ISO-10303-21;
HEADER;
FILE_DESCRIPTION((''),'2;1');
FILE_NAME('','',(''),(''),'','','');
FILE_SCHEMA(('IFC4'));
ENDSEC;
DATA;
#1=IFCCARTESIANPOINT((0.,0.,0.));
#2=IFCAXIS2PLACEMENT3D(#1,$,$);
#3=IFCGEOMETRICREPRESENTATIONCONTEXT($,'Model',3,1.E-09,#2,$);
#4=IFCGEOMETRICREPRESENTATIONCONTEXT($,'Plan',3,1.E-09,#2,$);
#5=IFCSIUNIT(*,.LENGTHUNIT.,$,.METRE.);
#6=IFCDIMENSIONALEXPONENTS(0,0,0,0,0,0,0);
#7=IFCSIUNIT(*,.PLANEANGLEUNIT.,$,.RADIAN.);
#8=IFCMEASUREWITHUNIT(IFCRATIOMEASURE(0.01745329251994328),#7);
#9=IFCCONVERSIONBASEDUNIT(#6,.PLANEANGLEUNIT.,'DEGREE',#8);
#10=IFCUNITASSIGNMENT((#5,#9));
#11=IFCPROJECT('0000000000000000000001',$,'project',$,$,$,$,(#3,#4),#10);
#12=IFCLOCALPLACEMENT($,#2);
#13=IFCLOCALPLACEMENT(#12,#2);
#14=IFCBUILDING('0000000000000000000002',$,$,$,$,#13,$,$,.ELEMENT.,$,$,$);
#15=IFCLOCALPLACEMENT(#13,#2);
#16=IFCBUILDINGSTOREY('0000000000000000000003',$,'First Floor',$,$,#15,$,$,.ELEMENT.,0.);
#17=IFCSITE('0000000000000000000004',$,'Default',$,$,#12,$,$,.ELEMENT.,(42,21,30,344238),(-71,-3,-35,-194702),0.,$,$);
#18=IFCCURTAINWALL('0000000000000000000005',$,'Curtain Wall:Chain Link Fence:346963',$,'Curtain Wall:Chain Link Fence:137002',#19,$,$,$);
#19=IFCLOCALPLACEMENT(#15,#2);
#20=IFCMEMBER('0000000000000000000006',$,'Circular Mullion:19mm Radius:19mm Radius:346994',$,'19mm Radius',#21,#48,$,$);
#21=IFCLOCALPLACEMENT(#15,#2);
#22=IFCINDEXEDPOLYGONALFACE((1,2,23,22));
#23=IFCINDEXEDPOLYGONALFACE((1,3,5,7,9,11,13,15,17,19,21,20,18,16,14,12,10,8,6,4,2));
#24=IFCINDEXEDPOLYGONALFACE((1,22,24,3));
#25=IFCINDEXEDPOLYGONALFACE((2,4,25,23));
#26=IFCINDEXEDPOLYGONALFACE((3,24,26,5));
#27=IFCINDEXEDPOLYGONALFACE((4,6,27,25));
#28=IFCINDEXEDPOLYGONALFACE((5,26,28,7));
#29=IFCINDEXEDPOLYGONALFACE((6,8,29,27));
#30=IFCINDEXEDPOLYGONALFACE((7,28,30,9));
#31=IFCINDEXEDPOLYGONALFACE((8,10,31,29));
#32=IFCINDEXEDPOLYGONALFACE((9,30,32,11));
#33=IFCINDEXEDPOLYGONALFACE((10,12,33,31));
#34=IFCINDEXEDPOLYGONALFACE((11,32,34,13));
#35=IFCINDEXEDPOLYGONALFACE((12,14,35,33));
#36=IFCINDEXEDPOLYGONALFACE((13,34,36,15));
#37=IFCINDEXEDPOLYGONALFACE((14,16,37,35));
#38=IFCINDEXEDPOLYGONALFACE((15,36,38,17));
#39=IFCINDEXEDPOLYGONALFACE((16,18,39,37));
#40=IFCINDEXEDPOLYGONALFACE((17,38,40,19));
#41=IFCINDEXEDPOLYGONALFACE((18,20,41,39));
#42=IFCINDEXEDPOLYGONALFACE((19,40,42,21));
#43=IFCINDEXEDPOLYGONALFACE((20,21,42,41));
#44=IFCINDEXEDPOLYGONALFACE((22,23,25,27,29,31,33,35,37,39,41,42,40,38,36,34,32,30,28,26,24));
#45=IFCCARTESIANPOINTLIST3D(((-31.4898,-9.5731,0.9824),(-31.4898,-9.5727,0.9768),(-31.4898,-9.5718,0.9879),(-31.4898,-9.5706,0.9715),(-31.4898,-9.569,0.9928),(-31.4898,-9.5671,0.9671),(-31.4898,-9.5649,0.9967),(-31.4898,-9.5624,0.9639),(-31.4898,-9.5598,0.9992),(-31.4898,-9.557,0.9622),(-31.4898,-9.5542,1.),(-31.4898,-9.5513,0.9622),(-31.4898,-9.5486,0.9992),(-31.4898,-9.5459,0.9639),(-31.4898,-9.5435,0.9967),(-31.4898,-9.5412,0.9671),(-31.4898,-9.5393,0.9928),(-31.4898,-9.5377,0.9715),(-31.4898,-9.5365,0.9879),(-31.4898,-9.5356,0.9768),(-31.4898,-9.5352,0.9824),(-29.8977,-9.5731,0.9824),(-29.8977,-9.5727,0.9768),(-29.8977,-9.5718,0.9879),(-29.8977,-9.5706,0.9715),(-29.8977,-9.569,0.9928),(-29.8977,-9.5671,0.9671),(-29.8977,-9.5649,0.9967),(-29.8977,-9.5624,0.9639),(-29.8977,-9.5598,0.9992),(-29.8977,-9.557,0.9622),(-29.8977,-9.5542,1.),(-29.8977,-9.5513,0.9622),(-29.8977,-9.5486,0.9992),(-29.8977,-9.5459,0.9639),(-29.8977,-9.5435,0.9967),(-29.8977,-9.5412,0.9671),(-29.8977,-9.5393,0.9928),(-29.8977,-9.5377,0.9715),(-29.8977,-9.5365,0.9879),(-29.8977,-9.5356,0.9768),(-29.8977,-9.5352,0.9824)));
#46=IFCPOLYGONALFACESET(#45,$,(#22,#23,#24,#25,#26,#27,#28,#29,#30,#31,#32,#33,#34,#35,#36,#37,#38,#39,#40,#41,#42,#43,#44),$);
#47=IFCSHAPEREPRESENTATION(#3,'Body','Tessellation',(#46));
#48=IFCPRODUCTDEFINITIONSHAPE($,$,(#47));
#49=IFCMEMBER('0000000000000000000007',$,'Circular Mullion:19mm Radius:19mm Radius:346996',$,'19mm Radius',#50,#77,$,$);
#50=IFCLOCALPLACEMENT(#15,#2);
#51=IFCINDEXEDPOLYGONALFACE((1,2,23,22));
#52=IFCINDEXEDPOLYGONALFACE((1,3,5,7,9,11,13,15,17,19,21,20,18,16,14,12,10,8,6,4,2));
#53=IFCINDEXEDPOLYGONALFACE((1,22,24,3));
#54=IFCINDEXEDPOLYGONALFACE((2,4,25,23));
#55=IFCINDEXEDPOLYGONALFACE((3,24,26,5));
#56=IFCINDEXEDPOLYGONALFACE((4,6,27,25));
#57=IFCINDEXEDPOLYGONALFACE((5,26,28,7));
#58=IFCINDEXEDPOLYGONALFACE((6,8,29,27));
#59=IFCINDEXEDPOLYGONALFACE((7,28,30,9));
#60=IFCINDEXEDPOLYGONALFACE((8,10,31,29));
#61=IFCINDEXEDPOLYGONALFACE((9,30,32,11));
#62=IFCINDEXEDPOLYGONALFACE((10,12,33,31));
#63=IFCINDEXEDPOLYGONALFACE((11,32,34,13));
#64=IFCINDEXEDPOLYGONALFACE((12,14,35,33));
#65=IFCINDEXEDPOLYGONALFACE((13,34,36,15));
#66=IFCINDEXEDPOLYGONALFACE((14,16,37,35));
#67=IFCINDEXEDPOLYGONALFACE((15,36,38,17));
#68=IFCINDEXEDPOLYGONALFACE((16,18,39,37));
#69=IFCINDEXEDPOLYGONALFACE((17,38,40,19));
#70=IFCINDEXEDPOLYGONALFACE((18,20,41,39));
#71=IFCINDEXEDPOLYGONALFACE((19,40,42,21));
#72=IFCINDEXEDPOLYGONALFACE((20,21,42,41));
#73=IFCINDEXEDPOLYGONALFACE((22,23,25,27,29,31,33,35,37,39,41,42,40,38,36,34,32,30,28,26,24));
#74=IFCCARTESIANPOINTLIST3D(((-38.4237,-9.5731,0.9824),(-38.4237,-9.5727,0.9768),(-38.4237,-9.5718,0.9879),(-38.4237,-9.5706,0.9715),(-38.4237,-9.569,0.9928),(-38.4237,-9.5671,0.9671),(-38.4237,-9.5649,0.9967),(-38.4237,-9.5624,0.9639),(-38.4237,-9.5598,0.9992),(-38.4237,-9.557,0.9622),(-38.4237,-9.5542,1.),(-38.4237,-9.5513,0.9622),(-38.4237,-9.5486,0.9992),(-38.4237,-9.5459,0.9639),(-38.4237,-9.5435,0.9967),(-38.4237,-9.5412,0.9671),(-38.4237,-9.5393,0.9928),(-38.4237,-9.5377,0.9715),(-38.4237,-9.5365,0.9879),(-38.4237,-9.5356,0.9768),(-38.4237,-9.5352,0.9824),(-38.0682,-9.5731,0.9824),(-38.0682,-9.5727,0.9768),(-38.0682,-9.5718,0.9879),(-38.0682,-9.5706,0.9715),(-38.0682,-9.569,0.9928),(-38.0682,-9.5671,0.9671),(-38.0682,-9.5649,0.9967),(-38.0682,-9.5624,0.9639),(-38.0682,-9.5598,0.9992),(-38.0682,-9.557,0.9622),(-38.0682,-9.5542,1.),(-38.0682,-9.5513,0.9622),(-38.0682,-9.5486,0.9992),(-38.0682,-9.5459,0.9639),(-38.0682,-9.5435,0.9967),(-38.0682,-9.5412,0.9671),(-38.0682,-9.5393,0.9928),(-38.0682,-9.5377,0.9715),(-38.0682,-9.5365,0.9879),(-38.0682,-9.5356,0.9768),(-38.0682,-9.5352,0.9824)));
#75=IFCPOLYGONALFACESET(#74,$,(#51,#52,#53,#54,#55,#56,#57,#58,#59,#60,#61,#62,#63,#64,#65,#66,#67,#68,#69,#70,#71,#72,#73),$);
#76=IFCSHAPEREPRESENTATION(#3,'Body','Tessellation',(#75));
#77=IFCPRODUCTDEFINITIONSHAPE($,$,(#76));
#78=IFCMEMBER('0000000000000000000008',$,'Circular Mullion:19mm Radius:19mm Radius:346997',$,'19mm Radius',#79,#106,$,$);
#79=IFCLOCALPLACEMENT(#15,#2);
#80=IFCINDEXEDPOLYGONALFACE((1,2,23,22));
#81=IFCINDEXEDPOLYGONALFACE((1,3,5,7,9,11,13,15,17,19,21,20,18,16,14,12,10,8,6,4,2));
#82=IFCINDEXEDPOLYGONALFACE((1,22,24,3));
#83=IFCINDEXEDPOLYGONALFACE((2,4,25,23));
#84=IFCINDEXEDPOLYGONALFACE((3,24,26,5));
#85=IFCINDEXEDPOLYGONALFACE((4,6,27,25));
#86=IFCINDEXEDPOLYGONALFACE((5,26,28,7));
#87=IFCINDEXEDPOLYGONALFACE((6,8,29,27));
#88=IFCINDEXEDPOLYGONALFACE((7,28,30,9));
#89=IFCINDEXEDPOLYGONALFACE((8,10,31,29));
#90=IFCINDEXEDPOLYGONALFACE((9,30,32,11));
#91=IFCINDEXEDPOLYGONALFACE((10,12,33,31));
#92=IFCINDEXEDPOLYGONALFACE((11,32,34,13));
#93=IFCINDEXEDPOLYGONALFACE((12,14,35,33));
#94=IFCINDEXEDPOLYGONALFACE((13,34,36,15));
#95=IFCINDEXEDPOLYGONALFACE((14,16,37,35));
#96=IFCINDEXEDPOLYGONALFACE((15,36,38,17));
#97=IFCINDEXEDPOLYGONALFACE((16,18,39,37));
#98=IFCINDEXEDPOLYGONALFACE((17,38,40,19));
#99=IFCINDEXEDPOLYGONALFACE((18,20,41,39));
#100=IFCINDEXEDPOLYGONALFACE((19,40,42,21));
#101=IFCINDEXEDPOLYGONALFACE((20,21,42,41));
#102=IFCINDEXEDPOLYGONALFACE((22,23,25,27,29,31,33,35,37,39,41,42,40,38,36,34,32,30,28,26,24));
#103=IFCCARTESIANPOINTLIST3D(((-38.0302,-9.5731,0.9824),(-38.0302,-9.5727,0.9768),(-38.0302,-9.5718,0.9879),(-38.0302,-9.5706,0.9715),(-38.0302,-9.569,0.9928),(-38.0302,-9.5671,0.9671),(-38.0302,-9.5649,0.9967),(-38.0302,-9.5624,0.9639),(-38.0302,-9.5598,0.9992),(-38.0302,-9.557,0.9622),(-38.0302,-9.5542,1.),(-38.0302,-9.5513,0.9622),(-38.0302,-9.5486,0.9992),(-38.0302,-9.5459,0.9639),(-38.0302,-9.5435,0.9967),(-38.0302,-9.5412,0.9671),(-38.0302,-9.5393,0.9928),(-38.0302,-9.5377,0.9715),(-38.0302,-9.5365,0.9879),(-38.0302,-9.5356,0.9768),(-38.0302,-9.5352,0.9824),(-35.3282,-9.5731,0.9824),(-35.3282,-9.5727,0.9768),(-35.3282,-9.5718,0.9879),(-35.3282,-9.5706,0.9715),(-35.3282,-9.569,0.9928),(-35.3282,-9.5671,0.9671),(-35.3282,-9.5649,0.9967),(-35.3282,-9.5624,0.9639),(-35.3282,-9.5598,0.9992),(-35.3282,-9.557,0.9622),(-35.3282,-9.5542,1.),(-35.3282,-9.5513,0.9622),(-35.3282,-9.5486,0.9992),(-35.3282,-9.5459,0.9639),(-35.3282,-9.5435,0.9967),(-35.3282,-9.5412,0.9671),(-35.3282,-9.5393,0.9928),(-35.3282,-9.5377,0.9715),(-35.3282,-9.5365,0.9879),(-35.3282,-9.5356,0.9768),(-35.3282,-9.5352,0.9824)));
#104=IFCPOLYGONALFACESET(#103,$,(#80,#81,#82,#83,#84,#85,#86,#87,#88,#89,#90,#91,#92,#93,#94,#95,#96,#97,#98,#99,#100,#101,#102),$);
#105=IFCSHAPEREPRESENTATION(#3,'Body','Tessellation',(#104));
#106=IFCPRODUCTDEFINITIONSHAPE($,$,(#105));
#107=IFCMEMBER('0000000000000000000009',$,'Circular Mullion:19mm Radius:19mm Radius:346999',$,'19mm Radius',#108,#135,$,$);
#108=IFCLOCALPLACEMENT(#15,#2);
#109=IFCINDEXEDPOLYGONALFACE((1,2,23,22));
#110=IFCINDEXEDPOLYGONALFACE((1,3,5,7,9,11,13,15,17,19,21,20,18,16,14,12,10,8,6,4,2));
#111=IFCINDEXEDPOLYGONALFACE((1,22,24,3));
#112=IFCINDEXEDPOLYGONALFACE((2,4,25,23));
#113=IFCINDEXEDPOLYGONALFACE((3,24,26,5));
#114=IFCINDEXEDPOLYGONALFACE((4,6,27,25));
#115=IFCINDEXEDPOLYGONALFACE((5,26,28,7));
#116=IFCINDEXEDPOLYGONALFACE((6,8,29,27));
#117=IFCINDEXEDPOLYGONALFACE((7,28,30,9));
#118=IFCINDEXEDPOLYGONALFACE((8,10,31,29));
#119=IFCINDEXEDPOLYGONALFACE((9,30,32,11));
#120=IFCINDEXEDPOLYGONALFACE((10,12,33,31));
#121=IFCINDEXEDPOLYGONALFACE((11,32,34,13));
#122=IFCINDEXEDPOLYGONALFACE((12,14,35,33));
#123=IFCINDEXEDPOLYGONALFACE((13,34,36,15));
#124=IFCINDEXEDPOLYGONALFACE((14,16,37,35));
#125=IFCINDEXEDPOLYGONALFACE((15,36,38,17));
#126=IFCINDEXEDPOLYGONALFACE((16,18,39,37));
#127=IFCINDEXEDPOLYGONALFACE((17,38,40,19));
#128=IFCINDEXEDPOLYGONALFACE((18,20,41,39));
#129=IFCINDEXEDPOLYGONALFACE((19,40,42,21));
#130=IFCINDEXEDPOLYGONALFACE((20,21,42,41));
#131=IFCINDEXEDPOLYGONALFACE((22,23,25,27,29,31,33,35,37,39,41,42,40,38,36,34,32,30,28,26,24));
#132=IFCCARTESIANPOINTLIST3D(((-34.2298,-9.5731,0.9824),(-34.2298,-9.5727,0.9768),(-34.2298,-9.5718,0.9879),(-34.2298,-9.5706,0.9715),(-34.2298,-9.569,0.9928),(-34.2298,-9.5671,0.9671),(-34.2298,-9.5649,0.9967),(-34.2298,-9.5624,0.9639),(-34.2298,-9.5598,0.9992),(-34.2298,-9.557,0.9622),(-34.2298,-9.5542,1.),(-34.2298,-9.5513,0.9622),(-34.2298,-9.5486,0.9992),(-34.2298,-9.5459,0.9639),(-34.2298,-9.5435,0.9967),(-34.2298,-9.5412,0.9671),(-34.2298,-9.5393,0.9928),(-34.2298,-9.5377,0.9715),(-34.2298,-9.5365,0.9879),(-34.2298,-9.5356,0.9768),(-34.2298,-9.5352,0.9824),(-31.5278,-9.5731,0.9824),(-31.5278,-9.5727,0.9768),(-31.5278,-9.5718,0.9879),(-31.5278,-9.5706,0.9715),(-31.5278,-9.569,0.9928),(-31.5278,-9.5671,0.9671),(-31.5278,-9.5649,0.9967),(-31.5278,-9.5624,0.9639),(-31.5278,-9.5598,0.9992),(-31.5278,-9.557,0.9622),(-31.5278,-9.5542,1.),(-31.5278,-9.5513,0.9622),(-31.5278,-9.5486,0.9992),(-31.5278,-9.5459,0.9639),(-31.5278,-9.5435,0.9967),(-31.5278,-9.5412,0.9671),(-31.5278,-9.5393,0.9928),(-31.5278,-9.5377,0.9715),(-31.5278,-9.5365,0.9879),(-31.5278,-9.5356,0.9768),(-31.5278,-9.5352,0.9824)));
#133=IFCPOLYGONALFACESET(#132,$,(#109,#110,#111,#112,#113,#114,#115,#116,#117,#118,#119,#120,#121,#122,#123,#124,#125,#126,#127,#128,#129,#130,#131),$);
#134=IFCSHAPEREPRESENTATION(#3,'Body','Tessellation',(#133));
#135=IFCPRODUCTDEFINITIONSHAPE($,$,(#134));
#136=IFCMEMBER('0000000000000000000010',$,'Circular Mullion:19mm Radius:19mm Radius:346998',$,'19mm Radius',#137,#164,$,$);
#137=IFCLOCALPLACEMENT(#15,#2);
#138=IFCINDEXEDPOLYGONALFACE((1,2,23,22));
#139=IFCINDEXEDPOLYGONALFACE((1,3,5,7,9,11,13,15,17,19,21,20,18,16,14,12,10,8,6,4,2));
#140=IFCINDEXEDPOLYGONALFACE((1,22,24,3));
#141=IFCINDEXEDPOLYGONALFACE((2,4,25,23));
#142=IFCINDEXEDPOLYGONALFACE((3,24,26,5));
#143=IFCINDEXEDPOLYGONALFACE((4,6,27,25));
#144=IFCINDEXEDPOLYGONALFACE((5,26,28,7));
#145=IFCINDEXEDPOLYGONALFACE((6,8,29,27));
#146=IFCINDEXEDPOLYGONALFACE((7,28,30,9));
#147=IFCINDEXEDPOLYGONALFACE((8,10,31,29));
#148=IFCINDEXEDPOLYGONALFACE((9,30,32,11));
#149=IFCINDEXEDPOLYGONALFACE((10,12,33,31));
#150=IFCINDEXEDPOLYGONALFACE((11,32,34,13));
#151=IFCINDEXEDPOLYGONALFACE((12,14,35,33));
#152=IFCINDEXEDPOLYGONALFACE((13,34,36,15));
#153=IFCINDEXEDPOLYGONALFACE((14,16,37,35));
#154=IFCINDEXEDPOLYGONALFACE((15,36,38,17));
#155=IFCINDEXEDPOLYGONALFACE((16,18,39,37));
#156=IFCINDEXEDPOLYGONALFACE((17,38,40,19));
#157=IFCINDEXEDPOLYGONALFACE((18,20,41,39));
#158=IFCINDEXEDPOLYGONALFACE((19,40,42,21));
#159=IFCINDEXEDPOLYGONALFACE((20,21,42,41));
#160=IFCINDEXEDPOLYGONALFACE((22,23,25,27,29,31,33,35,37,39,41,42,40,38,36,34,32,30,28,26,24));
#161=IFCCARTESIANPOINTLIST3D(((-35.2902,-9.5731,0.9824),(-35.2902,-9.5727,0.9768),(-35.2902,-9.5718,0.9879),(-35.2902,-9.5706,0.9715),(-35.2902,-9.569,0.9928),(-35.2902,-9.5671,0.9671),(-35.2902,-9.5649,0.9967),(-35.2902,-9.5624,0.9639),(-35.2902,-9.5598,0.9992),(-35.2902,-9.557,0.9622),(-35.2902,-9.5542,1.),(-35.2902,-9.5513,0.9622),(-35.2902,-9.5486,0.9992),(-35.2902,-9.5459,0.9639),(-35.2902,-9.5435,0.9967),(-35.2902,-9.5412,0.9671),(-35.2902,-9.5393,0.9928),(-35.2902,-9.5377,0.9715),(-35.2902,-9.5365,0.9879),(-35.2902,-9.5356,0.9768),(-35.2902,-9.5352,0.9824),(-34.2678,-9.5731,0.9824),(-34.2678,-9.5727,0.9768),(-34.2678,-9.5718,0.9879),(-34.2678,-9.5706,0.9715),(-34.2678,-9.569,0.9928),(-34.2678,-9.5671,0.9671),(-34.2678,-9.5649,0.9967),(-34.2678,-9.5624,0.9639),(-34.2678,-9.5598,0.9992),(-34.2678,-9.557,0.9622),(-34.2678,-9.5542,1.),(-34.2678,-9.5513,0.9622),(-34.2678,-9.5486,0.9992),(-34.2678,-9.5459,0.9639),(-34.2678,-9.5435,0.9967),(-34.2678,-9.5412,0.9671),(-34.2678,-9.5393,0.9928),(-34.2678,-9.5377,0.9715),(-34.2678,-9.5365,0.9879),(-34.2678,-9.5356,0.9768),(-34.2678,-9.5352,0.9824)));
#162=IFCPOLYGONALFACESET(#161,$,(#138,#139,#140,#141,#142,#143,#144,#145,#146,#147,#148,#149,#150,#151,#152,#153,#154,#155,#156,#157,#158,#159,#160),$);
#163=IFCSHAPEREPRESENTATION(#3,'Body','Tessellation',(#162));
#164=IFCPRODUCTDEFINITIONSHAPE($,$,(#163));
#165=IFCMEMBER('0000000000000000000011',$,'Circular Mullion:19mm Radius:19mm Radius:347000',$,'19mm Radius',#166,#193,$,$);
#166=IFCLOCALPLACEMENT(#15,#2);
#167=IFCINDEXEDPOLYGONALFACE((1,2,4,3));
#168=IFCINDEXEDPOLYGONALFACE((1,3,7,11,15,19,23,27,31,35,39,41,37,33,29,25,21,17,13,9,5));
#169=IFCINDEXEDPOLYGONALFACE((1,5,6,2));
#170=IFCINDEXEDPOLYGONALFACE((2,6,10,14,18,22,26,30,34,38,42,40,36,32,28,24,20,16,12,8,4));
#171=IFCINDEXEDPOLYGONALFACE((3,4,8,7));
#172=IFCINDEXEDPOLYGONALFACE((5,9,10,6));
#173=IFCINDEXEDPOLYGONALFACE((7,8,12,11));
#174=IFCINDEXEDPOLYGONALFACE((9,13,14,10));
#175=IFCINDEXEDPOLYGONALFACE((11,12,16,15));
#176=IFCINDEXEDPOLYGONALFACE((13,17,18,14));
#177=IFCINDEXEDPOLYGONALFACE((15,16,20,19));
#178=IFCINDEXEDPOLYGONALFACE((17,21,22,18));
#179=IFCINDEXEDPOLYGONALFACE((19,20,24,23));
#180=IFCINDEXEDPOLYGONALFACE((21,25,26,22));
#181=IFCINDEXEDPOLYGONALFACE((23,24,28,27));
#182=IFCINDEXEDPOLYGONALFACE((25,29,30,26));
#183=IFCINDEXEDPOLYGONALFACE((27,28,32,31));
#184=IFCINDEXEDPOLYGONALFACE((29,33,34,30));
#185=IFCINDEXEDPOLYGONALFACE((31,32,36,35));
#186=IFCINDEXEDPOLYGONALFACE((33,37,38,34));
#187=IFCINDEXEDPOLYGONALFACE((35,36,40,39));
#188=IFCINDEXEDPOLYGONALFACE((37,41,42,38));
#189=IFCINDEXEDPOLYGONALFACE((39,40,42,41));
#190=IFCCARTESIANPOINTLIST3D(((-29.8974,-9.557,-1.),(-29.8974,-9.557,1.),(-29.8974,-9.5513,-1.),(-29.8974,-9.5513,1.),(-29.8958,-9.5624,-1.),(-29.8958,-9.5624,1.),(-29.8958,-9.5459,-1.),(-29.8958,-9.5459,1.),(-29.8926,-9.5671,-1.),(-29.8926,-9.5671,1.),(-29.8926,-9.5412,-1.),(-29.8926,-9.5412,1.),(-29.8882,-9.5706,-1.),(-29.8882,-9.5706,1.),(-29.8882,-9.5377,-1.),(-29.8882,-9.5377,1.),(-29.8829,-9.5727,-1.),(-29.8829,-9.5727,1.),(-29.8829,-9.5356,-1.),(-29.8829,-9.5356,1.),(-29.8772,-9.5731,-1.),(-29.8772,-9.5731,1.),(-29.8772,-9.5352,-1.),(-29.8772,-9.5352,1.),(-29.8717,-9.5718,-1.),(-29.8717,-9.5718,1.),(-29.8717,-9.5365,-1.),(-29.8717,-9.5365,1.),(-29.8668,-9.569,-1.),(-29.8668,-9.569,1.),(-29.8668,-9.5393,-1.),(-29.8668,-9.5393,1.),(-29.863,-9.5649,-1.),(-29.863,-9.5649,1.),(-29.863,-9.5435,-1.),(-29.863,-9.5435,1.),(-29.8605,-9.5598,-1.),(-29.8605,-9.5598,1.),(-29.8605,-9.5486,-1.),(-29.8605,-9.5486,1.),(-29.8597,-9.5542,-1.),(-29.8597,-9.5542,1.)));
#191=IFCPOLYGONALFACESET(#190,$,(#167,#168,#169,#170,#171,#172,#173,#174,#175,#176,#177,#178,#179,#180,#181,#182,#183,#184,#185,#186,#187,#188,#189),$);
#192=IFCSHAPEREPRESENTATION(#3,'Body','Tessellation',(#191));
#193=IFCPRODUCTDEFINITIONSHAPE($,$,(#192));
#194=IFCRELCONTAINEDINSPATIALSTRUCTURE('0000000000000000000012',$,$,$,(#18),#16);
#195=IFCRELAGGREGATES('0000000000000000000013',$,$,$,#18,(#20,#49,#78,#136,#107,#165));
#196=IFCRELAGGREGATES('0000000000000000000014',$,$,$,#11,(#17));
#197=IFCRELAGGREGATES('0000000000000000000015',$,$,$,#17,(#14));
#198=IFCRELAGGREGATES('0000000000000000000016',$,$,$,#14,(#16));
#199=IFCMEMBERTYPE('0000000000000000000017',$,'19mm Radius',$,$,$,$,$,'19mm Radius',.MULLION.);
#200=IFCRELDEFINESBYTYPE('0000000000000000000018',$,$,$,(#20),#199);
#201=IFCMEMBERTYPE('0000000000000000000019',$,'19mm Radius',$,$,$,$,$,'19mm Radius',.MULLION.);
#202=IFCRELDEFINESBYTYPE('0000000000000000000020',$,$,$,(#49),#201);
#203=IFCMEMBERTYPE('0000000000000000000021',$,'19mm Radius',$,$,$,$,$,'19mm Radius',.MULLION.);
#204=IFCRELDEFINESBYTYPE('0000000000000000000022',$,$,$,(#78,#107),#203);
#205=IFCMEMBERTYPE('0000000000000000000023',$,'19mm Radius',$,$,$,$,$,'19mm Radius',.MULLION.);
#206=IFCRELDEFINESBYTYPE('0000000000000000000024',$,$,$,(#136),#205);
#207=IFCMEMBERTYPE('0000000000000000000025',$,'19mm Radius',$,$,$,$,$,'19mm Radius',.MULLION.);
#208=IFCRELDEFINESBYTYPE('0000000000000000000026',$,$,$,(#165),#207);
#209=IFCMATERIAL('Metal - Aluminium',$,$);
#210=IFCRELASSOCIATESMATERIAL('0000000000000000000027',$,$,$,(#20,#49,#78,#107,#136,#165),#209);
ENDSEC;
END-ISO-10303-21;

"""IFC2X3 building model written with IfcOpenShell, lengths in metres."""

from ifc_helpers import new_model, entity, si_unit, converted_unit, frame, origin, origin_2d_with_axis, place, context, project, spatial, circle, extrude, source, transform, mapped, material, type_object, type_shapes, element, aggregate, save


model = new_model("IFC2X3")

# Units and contexts
model_context = context("Model", 3, precision=1e-09, world=origin())
plan_context = context("Plan", 3, precision=1e-09, world=origin())
ifc_project = project(units=[si_unit("LENGTHUNIT", "METRE"), converted_unit("PLANEANGLEUNIT", "DEGREE", entity("IfcRatioMeasure", 0.01745329251994328), si_unit("PLANEANGLEUNIT", "RADIAN"), dimensions=[0, 0, 0, 0, 0, 0, 0])], contexts=[model_context, plan_context])

# Site, building, storey
site_placement = place(None, origin())
site = spatial("IfcSite", under=ifc_project, at=site_placement, Name="Default", CompositionType="ELEMENT", RefLatitude=(42, 21, 30, 344238), RefLongitude=(-71, -3, -35, -194702), RefElevation=0.0)
building_placement = place(site_placement, origin())
building = spatial("IfcBuilding", under=site, at=building_placement, CompositionType="ELEMENT")
storey_placement = place(building_placement, origin())
storey = spatial("IfcBuildingStorey", under=building, at=storey_placement, Name="First Floor", CompositionType="ELEMENT", Elevation=0.0)

# Curtain wall, members
curtain_wall_1_placement = place(storey_placement, origin())
curtain_wall_1 = element("IfcCurtainWall", 1, at=curtain_wall_1_placement, inside=storey, Name="Curtain Wall:Chain Link Fence:346963", ObjectType="Curtain Wall:Chain Link Fence:137002")
ifc_material_1 = material(Name="Metal - Aluminium")
member_type_1 = type_object("IfcMemberType", Name="19mm Radius", ElementType="19mm Radius", PredefinedType="MULLION")
shared_shape_1 = source(origin(), model_context, "Body", "SweptSolid", [
    extrude(circle(Radius=0.019, at=origin_2d_with_axis()), frame((-0.019, 0.0, -1.5921)), (0.0, 0.0, 1.0), 1.5921),
])
type_shapes(member_type_1, [shared_shape_1])
member_1_placement = place(storey_placement, frame((-29.8977, -9.5542, 1.0), z_axis=(1.0, 0.0, 0.0), x_axis=(0.0, 0.0, 1.0)))
member_1 = element("IfcMember", 2, at=member_1_placement, type_object=member_type_1, material=ifc_material_1, Name="Circular Mullion:19mm Radius:19mm Radius:346994", ObjectType="19mm Radius", context=model_context, shape_type="MappedRepresentation", body=[
    mapped(shared_shape_1, transform((0.0, 0.0, 0.0), scale=1.0)),
])
member_type_2 = type_object("IfcMemberType", Name="19mm Radius", ElementType="19mm Radius", PredefinedType="MULLION")
shared_shape_2 = source(origin(), model_context, "Body", "SweptSolid", [
    extrude(circle(Radius=0.019, at=origin_2d_with_axis()), frame((-0.019, 0.0, -0.3556)), (0.0, 0.0, 1.0), 0.3556),
])
type_shapes(member_type_2, [shared_shape_2])
member_2_placement = place(storey_placement, frame((-38.0682, -9.5542, 1.0), z_axis=(1.0, 0.0, 0.0), x_axis=(0.0, 0.0, 1.0)))
member_2 = element("IfcMember", 3, at=member_2_placement, type_object=member_type_2, material=ifc_material_1, Name="Circular Mullion:19mm Radius:19mm Radius:346996", ObjectType="19mm Radius", context=model_context, shape_type="MappedRepresentation", body=[
    mapped(shared_shape_2, transform((0.0, 0.0, 0.0), scale=1.0)),
])
member_type_3 = type_object("IfcMemberType", Name="19mm Radius", ElementType="19mm Radius", PredefinedType="MULLION")
shared_shape_3 = source(origin(), model_context, "Body", "SweptSolid", [
    extrude(circle(Radius=0.019, at=origin_2d_with_axis()), frame((-0.019, 0.0, -2.702)), (0.0, 0.0, 1.0), 2.702),
])
type_shapes(member_type_3, [shared_shape_3])
member_3_placement = place(storey_placement, frame((-35.3282, -9.5542, 1.0), z_axis=(1.0, 0.0, 0.0), x_axis=(0.0, 0.0, 1.0)))
member_3 = element("IfcMember", 4, at=member_3_placement, type_object=member_type_3, material=ifc_material_1, Name="Circular Mullion:19mm Radius:19mm Radius:346997", ObjectType="19mm Radius", context=model_context, shape_type="MappedRepresentation", body=[
    mapped(shared_shape_3, transform((0.0, 0.0, 0.0), scale=1.0)),
])
member_4_placement = place(storey_placement, frame((-31.5278, -9.5542, 1.0), z_axis=(1.0, 0.0, 0.0), x_axis=(0.0, 0.0, 1.0)))
member_4 = element("IfcMember", 5, at=member_4_placement, type_object=member_type_3, material=ifc_material_1, Name="Circular Mullion:19mm Radius:19mm Radius:346999", ObjectType="19mm Radius", context=model_context, shape_type="MappedRepresentation", body=[
    mapped(shared_shape_3, transform((0.0, 0.0, 0.0), scale=1.0)),
])
member_type_4 = type_object("IfcMemberType", Name="19mm Radius", ElementType="19mm Radius", PredefinedType="MULLION")
shared_shape_4 = source(origin(), model_context, "Body", "SweptSolid", [
    extrude(circle(Radius=0.019, at=origin_2d_with_axis()), frame((-0.019, 0.0, -1.0224)), (0.0, 0.0, 1.0), 1.0224),
])
type_shapes(member_type_4, [shared_shape_4])
member_5_placement = place(storey_placement, frame((-34.2678, -9.5542, 1.0), z_axis=(1.0, 0.0, 0.0), x_axis=(0.0, 0.0, 1.0)))
member_5 = element("IfcMember", 6, at=member_5_placement, type_object=member_type_4, material=ifc_material_1, Name="Circular Mullion:19mm Radius:19mm Radius:346998", ObjectType="19mm Radius", context=model_context, shape_type="MappedRepresentation", body=[
    mapped(shared_shape_4, transform((0.0, 0.0, 0.0), scale=1.0)),
])
member_type_5 = type_object("IfcMemberType", Name="19mm Radius", ElementType="19mm Radius", PredefinedType="MULLION")
shared_shape_5 = source(origin(), model_context, "Body", "SweptSolid", [
    extrude(circle(Radius=0.019, at=origin_2d_with_axis()), frame((-0.019, 0.0, -2.0)), (0.0, 0.0, 1.0), 2.0),
])
type_shapes(member_type_5, [shared_shape_5])
placement = place(building_placement, frame((0.0, 0.0, -1.0)))
member_6_placement = place(placement, frame((-29.8597, -9.5542, 0.0), z_axis=(0.0, 0.0, -1.0), x_axis=(1.0, 0.0, 0.0)))
member_6 = element("IfcMember", 7, at=member_6_placement, type_object=member_type_5, material=ifc_material_1, Name="Circular Mullion:19mm Radius:19mm Radius:347000", ObjectType="19mm Radius", context=model_context, shape_type="MappedRepresentation", body=[
    mapped(shared_shape_5, transform((0.0, 0.0, 0.0), scale=1.0)),
])

aggregate(curtain_wall_1, [member_1, member_2, member_3, member_5, member_4, member_6])

save(model, "model.ifc")
